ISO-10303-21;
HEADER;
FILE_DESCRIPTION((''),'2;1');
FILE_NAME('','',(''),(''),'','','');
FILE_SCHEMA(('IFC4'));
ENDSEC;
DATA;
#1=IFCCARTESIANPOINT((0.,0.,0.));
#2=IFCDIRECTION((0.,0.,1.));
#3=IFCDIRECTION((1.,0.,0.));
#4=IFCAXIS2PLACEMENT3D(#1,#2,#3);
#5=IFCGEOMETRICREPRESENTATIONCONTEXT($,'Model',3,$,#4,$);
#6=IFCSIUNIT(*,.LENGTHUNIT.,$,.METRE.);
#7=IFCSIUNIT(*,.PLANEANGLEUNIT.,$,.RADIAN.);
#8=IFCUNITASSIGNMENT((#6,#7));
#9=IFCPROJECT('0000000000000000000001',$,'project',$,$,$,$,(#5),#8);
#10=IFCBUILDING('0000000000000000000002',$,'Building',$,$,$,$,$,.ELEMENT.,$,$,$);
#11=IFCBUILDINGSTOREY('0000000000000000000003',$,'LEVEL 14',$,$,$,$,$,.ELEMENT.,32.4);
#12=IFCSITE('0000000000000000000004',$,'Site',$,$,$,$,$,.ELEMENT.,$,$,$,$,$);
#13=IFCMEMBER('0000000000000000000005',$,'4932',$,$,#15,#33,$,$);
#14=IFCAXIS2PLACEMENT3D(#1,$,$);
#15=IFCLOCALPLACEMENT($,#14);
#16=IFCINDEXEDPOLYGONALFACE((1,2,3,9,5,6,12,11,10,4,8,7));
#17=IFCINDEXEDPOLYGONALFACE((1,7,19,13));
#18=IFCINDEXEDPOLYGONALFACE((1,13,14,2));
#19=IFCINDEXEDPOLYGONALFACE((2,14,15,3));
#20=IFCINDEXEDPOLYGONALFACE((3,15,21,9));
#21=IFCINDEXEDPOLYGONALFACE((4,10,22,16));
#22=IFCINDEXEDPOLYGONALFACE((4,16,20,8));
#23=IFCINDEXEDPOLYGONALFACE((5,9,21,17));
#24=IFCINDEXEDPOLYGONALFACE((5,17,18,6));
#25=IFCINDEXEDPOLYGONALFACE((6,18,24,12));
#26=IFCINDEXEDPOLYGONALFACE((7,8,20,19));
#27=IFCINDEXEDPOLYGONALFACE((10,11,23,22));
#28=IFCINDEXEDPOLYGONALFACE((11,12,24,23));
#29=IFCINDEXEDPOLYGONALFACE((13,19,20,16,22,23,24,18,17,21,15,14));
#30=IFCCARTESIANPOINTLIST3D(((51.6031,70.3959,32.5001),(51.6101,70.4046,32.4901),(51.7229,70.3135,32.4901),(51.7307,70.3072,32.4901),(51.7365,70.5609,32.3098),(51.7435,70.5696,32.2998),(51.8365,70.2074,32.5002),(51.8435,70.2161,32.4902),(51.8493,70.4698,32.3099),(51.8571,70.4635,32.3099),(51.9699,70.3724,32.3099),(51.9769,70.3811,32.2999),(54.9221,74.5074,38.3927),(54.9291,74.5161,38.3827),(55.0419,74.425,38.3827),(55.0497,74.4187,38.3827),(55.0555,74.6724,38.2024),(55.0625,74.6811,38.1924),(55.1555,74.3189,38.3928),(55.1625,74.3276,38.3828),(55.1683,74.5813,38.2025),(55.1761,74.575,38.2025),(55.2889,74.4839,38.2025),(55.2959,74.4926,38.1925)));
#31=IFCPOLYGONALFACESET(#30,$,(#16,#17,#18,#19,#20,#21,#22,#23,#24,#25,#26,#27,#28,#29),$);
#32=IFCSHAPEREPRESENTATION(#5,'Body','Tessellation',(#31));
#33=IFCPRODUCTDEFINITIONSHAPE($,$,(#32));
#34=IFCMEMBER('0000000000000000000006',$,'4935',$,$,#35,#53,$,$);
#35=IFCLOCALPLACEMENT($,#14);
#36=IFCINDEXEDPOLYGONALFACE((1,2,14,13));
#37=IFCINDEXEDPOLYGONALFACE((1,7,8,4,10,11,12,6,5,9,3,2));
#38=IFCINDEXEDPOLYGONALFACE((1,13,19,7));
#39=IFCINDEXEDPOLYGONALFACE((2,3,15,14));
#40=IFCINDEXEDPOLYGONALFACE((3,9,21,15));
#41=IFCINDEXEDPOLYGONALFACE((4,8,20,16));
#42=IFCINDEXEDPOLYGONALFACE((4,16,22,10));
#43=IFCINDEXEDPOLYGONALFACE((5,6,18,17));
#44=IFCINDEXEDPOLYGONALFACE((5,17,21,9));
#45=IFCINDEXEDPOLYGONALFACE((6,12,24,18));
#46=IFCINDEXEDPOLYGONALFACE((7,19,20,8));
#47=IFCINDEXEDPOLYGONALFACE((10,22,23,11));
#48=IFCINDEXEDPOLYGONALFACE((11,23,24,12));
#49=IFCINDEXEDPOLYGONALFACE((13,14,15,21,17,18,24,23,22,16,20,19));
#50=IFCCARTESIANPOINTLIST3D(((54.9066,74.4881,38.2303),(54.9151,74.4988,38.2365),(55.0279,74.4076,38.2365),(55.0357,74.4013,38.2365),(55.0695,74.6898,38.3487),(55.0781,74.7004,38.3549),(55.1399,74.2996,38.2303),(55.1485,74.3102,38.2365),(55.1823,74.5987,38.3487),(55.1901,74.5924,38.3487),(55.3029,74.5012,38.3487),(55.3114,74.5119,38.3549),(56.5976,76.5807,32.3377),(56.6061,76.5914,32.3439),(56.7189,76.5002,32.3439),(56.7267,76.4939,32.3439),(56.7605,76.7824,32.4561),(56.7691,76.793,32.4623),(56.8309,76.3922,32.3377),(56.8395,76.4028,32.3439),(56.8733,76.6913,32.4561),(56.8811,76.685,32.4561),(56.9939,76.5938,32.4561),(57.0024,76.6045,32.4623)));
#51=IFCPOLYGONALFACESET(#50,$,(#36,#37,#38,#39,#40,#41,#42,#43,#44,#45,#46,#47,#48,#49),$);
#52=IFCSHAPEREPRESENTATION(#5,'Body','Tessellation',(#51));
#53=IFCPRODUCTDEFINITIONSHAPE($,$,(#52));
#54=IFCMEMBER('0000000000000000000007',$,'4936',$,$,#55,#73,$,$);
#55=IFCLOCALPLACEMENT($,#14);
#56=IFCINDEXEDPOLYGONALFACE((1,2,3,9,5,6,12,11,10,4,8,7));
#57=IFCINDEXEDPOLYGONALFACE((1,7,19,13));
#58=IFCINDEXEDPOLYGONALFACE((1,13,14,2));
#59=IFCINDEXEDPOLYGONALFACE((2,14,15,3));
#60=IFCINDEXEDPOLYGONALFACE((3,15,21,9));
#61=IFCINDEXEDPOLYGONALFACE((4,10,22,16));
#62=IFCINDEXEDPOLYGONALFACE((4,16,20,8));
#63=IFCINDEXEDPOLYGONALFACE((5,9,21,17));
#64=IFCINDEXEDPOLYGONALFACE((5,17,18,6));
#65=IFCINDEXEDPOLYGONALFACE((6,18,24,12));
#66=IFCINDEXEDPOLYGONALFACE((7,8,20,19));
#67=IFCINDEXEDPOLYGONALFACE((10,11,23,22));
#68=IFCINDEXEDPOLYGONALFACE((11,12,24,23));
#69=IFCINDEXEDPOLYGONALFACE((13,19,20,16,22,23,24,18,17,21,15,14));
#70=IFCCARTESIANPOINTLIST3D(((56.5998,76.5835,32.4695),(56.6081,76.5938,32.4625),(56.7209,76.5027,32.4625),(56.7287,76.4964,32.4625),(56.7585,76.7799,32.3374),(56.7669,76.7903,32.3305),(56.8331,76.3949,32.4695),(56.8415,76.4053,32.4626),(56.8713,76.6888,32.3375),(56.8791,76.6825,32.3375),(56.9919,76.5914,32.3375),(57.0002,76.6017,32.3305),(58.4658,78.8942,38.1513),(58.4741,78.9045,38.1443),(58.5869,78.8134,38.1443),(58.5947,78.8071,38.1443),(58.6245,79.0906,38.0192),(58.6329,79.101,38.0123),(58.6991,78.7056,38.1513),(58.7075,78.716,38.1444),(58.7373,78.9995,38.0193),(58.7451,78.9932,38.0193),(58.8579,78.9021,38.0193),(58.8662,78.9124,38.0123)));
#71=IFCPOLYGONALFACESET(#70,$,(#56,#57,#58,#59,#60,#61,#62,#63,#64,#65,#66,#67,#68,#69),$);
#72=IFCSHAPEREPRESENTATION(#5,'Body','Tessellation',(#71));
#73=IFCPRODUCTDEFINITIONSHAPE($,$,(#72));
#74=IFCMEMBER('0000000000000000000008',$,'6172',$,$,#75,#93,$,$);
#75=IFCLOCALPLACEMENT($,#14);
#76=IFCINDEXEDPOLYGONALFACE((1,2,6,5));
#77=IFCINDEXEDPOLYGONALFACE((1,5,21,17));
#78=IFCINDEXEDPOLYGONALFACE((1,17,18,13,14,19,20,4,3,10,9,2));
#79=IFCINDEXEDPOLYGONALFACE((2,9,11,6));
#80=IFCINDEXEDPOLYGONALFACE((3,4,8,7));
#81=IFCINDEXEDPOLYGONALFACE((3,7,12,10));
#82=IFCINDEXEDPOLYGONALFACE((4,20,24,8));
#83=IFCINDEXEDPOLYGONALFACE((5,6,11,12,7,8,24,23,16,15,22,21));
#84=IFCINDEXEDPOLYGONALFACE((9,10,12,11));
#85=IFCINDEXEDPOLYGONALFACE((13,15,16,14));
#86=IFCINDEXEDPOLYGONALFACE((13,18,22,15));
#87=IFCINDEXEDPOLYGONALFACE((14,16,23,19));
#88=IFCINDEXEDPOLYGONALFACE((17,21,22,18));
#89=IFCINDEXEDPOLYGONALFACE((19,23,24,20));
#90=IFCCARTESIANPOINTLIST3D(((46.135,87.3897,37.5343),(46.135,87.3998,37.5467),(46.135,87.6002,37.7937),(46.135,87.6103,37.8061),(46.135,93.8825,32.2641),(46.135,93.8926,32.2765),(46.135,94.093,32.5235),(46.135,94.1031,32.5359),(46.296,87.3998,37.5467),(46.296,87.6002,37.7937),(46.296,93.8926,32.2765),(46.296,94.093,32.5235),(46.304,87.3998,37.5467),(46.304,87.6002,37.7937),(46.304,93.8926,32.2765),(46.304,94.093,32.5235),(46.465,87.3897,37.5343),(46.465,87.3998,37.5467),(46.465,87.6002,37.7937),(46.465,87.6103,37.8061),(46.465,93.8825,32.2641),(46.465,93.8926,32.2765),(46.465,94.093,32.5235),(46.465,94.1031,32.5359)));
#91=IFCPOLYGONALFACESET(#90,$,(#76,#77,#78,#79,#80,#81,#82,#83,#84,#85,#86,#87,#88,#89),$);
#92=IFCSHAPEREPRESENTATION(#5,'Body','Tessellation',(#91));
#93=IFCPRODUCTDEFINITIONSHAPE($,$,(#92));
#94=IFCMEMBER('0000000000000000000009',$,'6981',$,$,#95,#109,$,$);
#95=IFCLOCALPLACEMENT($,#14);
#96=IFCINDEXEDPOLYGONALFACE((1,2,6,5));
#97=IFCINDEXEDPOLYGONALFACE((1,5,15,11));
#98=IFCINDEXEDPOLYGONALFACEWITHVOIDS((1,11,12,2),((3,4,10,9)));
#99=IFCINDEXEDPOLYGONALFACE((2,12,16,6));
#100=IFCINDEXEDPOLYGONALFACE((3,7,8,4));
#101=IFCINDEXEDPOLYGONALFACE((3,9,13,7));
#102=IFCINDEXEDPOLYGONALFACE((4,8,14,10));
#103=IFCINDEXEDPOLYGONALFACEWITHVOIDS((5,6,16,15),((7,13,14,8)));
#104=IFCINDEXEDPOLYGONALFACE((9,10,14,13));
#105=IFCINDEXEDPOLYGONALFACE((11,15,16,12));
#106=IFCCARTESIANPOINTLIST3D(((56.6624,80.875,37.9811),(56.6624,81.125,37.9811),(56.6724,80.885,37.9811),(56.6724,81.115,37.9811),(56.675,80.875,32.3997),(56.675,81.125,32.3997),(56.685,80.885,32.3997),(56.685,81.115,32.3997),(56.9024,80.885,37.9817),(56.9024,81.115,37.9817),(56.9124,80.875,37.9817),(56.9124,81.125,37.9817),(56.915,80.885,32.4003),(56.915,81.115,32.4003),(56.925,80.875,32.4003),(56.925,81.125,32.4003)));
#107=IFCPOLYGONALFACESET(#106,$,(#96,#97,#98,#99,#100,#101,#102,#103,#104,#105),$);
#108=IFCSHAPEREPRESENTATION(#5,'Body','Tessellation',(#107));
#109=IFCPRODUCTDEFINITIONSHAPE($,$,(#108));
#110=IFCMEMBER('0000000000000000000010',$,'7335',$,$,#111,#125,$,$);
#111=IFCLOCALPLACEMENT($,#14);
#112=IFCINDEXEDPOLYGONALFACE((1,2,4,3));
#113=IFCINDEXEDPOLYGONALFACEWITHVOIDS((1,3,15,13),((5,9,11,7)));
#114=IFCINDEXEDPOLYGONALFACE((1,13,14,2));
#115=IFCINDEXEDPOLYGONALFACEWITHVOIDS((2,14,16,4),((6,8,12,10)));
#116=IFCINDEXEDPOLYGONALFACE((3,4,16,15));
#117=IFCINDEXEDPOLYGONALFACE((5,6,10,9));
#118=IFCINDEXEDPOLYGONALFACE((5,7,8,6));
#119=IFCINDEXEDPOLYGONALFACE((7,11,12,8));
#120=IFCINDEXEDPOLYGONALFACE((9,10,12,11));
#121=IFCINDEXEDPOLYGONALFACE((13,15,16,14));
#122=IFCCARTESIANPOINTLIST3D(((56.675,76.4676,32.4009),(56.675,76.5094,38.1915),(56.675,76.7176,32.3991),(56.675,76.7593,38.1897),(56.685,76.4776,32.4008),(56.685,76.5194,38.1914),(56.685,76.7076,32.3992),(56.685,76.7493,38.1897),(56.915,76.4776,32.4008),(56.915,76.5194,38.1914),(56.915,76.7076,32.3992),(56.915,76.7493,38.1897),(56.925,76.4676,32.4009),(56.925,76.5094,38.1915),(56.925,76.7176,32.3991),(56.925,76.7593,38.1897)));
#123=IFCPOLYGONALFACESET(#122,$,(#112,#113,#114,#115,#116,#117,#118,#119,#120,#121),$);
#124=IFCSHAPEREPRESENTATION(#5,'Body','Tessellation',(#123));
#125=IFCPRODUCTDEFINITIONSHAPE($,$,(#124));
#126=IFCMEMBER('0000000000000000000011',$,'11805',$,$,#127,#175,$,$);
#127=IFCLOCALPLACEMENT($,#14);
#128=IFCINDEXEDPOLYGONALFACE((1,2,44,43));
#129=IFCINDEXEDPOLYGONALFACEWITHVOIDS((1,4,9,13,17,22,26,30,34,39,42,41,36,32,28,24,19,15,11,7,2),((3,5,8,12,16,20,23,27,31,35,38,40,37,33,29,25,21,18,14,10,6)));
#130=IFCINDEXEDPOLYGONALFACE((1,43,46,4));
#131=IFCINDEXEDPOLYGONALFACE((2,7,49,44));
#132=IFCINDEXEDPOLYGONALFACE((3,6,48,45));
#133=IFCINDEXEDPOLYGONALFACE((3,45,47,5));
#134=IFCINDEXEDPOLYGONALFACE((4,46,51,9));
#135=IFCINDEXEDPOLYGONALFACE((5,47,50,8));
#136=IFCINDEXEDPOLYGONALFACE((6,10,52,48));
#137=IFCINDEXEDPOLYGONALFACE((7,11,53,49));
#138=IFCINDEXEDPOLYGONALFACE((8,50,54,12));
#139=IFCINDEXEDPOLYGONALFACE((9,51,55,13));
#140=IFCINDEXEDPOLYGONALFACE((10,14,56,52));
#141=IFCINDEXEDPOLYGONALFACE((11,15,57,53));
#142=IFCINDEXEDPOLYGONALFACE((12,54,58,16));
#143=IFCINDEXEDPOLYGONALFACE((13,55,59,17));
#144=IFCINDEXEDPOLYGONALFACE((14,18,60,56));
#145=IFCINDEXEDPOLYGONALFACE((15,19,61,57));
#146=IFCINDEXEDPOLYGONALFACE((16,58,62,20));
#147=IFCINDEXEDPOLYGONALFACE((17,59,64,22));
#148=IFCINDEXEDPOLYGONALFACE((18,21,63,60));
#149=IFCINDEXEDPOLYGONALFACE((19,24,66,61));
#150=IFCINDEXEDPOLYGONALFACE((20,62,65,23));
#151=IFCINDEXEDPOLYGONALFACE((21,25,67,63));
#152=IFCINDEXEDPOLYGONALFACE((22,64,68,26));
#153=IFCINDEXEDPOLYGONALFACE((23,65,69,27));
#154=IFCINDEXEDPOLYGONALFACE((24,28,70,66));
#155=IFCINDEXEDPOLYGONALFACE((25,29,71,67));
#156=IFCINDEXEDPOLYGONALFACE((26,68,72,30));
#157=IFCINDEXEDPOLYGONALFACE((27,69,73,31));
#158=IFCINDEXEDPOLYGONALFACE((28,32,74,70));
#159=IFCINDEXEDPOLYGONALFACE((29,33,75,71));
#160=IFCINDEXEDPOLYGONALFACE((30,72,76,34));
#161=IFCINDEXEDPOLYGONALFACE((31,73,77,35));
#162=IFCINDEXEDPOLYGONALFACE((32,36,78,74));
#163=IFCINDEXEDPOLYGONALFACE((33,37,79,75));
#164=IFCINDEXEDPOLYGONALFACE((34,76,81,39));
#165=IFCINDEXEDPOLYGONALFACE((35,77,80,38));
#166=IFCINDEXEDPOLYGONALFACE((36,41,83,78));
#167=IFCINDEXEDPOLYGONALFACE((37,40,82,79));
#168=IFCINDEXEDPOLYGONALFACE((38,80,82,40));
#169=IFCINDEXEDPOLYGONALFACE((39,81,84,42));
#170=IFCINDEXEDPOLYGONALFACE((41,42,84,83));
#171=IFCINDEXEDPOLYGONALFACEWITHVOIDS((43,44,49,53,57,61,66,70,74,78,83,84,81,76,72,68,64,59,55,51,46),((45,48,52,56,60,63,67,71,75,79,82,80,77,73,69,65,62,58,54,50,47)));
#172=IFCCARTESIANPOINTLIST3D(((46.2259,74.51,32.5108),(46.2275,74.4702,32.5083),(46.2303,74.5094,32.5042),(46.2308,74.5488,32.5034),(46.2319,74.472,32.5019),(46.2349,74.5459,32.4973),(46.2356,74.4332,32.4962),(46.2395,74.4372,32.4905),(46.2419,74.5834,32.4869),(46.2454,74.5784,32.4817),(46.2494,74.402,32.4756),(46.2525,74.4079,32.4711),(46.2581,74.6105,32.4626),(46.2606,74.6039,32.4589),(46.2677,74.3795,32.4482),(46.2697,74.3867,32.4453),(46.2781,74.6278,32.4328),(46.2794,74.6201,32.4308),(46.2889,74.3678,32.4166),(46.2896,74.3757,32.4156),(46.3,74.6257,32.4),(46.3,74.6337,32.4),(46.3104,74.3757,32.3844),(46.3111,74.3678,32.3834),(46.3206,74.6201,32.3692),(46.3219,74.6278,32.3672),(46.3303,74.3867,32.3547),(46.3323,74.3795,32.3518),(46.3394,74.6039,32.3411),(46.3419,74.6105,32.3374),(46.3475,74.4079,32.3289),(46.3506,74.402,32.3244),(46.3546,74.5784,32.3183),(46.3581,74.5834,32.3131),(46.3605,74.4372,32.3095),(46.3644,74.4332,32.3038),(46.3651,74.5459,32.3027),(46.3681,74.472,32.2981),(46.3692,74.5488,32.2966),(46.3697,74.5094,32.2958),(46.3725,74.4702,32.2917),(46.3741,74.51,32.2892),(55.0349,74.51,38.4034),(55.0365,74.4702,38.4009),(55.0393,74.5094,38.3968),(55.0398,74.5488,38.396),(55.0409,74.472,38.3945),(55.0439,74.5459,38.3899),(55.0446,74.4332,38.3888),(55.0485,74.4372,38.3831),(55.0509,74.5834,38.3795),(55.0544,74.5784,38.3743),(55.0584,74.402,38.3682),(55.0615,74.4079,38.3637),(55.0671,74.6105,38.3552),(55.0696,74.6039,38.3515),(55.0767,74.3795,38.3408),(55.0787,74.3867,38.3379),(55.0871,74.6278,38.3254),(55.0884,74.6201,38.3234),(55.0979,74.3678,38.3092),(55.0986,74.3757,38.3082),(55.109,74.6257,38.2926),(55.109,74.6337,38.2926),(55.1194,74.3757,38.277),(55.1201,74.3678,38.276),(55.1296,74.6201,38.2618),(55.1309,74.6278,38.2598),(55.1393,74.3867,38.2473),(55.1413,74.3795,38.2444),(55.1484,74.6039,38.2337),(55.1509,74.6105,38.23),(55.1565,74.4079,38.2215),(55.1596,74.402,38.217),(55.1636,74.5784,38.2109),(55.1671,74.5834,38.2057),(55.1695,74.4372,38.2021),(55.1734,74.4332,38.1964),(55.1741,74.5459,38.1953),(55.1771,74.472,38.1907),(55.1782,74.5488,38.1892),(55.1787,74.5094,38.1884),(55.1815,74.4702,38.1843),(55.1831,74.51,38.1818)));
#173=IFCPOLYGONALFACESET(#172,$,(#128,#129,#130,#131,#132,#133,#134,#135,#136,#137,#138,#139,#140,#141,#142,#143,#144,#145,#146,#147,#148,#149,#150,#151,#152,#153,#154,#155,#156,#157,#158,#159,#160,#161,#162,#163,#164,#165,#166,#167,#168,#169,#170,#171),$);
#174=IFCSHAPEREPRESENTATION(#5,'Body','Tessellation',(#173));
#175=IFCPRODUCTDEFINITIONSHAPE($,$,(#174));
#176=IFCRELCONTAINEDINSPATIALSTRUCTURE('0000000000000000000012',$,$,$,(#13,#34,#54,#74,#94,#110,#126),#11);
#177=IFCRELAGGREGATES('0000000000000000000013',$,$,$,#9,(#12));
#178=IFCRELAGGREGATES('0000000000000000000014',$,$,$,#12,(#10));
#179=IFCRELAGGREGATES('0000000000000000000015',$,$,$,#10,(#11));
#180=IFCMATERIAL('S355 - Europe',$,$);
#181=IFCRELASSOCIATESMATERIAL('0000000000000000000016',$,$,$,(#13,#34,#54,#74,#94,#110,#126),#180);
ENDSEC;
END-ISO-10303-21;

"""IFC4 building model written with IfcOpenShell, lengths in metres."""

from ifc_helpers import new_model, si_unit, frame, origin_with_axes, origin_2d_with_axis, place, context, project, spatial, hollow_rectangle, hollow_circle, i_section, extrude, material, material_profile, profile_set, profile_usage, element, save


model = new_model("IFC4")

# Units and contexts
model_context = context("Model", 3, world=origin_with_axes())
ifc_project = project(units=[si_unit("LENGTHUNIT", "METRE"), si_unit("PLANEANGLEUNIT", "RADIAN")], contexts=[model_context])

# Site, building, storey
site = spatial("IfcSite", under=ifc_project, Name="Site", CompositionType="ELEMENT")
building = spatial("IfcBuilding", under=site, Name="Building", CompositionType="ELEMENT")
storey = spatial("IfcBuildingStorey", under=building, Name="LEVEL 14", CompositionType="ELEMENT", Elevation=32.4)

# Shared definitions
ifc_material = material(Name="S355 - Europe")

# Members
ifc_material_profile_1 = material_profile(ifc_material, i_section(OverallWidth=0.3, OverallDepth=0.3, WebThickness=0.01, FlangeThickness=0.015, at=origin_2d_with_axis()))
ifc_profile_set_1 = profile_set([ifc_material_profile_1])
ifc_profile_usage_1 = profile_usage(ifc_profile_set_1, cardinal=10)
member_1_placement = place(None, frame((51.79, 70.3885, 32.4), z_axis=(0.419345, 0.519475, 0.744511), x_axis=(-0.777826, 0.62848, 0.0)))
element("IfcMember", 1, at=member_1_placement, inside=storey, material=ifc_profile_usage_1, Name="4932", context=model_context, shape_type="SweptSolid", body=[
    extrude(i_section(OverallWidth=0.3, OverallDepth=0.3, WebThickness=0.01, FlangeThickness=0.015, at=origin_2d_with_axis()), origin_with_axes(), (0.0, 0.0, 1.0), 7.9147),
])
ifc_material_profile_2 = material_profile(ifc_material, i_section(OverallWidth=0.3, OverallDepth=0.3, WebThickness=0.01, FlangeThickness=0.015, at=origin_2d_with_axis()))
ifc_profile_set_2 = profile_set([ifc_material_profile_2])
ifc_profile_usage_2 = profile_usage(ifc_profile_set_2, cardinal=10)
member_2_placement = place(None, frame((55.109, 74.5, 38.2926), z_axis=(0.261048, 0.323044, -0.909668), x_axis=(-0.777826, 0.62848, 0.0)))
element("IfcMember", 2, at=member_2_placement, inside=storey, material=ifc_profile_usage_2, Name="4935", context=model_context, shape_type="SweptSolid", body=[
    extrude(i_section(OverallWidth=0.3, OverallDepth=0.3, WebThickness=0.01, FlangeThickness=0.015, at=origin_2d_with_axis()), origin_with_axes(), (0.0, 0.0, 1.0), 6.4777),
])
ifc_material_profile_3 = material_profile(ifc_material, i_section(OverallWidth=0.3, OverallDepth=0.3, WebThickness=0.01, FlangeThickness=0.015, at=origin_2d_with_axis()))
ifc_profile_set_3 = profile_set([ifc_material_profile_3])
ifc_profile_usage_3 = profile_usage(ifc_profile_set_3, cardinal=10)
member_3_placement = place(None, frame((56.8, 76.5926, 32.4), z_axis=(0.291051, 0.360413, 0.886223), x_axis=(-0.777826, 0.62848, 0.0)))
element("IfcMember", 3, at=member_3_placement, inside=storey, material=ifc_profile_usage_3, Name="4936", context=model_context, shape_type="SweptSolid", body=[
    extrude(i_section(OverallWidth=0.3, OverallDepth=0.3, WebThickness=0.01, FlangeThickness=0.015, at=origin_2d_with_axis()), origin_with_axes(), (0.0, 0.0, 1.0), 6.4113),
])
ifc_material_profile_4 = material_profile(ifc_material, i_section(OverallWidth=0.33, OverallDepth=0.35, WebThickness=0.008, FlangeThickness=0.016, at=origin_2d_with_axis()))
ifc_profile_set_4 = profile_set([ifc_material_profile_4])
ifc_profile_usage_4 = profile_usage(ifc_profile_set_4, cardinal=10)
member_4_placement = place(None, frame((46.3, 87.5, 37.6702), z_axis=(0.0, 0.776418, -0.630218), x_axis=(-1.0, 0.0, 0.0)))
element("IfcMember", 4, at=member_4_placement, inside=storey, material=ifc_profile_usage_4, Name="6172", context=model_context, shape_type="SweptSolid", body=[
    extrude(i_section(OverallWidth=0.33, OverallDepth=0.35, WebThickness=0.008, FlangeThickness=0.016, at=origin_2d_with_axis()), origin_with_axes(), (0.0, 0.0, 1.0), 8.3625),
])
ifc_material_profile_5 = material_profile(ifc_material, hollow_rectangle(XDim=0.25, YDim=0.25, WallThickness=0.01, at=origin_2d_with_axis()))
ifc_profile_set_5 = profile_set([ifc_material_profile_5])
ifc_profile_usage_5 = profile_usage(ifc_profile_set_5, cardinal=10)
member_5_placement = place(None, frame((56.8, 81.0, 32.4), z_axis=(-0.002257, 0.0, 0.999997), x_axis=(0.0, -1.0, 0.0)))
element("IfcMember", 5, at=member_5_placement, inside=storey, material=ifc_profile_usage_5, Name="6981", context=model_context, shape_type="SweptSolid", body=[
    extrude(hollow_rectangle(XDim=0.25, YDim=0.25, WallThickness=0.01, at=origin_2d_with_axis()), origin_with_axes(), (0.0, 0.0, 1.0), 5.5814),
])
ifc_material_profile_6 = material_profile(ifc_material, hollow_rectangle(XDim=0.25, YDim=0.25, WallThickness=0.01, at=origin_2d_with_axis()))
ifc_profile_set_6 = profile_set([ifc_material_profile_6])
ifc_profile_usage_6 = profile_usage(ifc_profile_set_6, cardinal=10)
member_6_placement = place(None, frame((56.8, 76.5926, 32.4), z_axis=(0.0, 0.00721, 0.999974), x_axis=(-1.0, 0.0, 0.0)))
element("IfcMember", 6, at=member_6_placement, inside=storey, material=ifc_profile_usage_6, Name="7335", context=model_context, shape_type="SweptSolid", body=[
    extrude(hollow_rectangle(XDim=0.25, YDim=0.25, WallThickness=0.01, at=origin_2d_with_axis()), origin_with_axes(), (0.0, 0.0, 1.0), 5.7907),
])
ifc_material_profile_7 = material_profile(ifc_material, hollow_circle(Radius=0.1337, WallThickness=0.008, at=origin_2d_with_axis()))
ifc_profile_set_7 = profile_set([ifc_material_profile_7])
ifc_profile_usage_7 = profile_usage(ifc_profile_set_7, cardinal=10)
member_7_placement = place(None, frame((46.3, 74.5, 32.4), z_axis=(0.831181, 0.0, 0.556002), x_axis=(0.0, 1.0, 0.0)))
element("IfcMember", 7, at=member_7_placement, inside=storey, material=ifc_profile_usage_7, Name="11805", context=model_context, shape_type="SweptSolid", body=[
    extrude(hollow_circle(Radius=0.1337, WallThickness=0.008, at=origin_2d_with_axis()), origin_with_axes(), (0.0, 0.0, 1.0), 10.5982),
])

save(model, "model.ifc")
